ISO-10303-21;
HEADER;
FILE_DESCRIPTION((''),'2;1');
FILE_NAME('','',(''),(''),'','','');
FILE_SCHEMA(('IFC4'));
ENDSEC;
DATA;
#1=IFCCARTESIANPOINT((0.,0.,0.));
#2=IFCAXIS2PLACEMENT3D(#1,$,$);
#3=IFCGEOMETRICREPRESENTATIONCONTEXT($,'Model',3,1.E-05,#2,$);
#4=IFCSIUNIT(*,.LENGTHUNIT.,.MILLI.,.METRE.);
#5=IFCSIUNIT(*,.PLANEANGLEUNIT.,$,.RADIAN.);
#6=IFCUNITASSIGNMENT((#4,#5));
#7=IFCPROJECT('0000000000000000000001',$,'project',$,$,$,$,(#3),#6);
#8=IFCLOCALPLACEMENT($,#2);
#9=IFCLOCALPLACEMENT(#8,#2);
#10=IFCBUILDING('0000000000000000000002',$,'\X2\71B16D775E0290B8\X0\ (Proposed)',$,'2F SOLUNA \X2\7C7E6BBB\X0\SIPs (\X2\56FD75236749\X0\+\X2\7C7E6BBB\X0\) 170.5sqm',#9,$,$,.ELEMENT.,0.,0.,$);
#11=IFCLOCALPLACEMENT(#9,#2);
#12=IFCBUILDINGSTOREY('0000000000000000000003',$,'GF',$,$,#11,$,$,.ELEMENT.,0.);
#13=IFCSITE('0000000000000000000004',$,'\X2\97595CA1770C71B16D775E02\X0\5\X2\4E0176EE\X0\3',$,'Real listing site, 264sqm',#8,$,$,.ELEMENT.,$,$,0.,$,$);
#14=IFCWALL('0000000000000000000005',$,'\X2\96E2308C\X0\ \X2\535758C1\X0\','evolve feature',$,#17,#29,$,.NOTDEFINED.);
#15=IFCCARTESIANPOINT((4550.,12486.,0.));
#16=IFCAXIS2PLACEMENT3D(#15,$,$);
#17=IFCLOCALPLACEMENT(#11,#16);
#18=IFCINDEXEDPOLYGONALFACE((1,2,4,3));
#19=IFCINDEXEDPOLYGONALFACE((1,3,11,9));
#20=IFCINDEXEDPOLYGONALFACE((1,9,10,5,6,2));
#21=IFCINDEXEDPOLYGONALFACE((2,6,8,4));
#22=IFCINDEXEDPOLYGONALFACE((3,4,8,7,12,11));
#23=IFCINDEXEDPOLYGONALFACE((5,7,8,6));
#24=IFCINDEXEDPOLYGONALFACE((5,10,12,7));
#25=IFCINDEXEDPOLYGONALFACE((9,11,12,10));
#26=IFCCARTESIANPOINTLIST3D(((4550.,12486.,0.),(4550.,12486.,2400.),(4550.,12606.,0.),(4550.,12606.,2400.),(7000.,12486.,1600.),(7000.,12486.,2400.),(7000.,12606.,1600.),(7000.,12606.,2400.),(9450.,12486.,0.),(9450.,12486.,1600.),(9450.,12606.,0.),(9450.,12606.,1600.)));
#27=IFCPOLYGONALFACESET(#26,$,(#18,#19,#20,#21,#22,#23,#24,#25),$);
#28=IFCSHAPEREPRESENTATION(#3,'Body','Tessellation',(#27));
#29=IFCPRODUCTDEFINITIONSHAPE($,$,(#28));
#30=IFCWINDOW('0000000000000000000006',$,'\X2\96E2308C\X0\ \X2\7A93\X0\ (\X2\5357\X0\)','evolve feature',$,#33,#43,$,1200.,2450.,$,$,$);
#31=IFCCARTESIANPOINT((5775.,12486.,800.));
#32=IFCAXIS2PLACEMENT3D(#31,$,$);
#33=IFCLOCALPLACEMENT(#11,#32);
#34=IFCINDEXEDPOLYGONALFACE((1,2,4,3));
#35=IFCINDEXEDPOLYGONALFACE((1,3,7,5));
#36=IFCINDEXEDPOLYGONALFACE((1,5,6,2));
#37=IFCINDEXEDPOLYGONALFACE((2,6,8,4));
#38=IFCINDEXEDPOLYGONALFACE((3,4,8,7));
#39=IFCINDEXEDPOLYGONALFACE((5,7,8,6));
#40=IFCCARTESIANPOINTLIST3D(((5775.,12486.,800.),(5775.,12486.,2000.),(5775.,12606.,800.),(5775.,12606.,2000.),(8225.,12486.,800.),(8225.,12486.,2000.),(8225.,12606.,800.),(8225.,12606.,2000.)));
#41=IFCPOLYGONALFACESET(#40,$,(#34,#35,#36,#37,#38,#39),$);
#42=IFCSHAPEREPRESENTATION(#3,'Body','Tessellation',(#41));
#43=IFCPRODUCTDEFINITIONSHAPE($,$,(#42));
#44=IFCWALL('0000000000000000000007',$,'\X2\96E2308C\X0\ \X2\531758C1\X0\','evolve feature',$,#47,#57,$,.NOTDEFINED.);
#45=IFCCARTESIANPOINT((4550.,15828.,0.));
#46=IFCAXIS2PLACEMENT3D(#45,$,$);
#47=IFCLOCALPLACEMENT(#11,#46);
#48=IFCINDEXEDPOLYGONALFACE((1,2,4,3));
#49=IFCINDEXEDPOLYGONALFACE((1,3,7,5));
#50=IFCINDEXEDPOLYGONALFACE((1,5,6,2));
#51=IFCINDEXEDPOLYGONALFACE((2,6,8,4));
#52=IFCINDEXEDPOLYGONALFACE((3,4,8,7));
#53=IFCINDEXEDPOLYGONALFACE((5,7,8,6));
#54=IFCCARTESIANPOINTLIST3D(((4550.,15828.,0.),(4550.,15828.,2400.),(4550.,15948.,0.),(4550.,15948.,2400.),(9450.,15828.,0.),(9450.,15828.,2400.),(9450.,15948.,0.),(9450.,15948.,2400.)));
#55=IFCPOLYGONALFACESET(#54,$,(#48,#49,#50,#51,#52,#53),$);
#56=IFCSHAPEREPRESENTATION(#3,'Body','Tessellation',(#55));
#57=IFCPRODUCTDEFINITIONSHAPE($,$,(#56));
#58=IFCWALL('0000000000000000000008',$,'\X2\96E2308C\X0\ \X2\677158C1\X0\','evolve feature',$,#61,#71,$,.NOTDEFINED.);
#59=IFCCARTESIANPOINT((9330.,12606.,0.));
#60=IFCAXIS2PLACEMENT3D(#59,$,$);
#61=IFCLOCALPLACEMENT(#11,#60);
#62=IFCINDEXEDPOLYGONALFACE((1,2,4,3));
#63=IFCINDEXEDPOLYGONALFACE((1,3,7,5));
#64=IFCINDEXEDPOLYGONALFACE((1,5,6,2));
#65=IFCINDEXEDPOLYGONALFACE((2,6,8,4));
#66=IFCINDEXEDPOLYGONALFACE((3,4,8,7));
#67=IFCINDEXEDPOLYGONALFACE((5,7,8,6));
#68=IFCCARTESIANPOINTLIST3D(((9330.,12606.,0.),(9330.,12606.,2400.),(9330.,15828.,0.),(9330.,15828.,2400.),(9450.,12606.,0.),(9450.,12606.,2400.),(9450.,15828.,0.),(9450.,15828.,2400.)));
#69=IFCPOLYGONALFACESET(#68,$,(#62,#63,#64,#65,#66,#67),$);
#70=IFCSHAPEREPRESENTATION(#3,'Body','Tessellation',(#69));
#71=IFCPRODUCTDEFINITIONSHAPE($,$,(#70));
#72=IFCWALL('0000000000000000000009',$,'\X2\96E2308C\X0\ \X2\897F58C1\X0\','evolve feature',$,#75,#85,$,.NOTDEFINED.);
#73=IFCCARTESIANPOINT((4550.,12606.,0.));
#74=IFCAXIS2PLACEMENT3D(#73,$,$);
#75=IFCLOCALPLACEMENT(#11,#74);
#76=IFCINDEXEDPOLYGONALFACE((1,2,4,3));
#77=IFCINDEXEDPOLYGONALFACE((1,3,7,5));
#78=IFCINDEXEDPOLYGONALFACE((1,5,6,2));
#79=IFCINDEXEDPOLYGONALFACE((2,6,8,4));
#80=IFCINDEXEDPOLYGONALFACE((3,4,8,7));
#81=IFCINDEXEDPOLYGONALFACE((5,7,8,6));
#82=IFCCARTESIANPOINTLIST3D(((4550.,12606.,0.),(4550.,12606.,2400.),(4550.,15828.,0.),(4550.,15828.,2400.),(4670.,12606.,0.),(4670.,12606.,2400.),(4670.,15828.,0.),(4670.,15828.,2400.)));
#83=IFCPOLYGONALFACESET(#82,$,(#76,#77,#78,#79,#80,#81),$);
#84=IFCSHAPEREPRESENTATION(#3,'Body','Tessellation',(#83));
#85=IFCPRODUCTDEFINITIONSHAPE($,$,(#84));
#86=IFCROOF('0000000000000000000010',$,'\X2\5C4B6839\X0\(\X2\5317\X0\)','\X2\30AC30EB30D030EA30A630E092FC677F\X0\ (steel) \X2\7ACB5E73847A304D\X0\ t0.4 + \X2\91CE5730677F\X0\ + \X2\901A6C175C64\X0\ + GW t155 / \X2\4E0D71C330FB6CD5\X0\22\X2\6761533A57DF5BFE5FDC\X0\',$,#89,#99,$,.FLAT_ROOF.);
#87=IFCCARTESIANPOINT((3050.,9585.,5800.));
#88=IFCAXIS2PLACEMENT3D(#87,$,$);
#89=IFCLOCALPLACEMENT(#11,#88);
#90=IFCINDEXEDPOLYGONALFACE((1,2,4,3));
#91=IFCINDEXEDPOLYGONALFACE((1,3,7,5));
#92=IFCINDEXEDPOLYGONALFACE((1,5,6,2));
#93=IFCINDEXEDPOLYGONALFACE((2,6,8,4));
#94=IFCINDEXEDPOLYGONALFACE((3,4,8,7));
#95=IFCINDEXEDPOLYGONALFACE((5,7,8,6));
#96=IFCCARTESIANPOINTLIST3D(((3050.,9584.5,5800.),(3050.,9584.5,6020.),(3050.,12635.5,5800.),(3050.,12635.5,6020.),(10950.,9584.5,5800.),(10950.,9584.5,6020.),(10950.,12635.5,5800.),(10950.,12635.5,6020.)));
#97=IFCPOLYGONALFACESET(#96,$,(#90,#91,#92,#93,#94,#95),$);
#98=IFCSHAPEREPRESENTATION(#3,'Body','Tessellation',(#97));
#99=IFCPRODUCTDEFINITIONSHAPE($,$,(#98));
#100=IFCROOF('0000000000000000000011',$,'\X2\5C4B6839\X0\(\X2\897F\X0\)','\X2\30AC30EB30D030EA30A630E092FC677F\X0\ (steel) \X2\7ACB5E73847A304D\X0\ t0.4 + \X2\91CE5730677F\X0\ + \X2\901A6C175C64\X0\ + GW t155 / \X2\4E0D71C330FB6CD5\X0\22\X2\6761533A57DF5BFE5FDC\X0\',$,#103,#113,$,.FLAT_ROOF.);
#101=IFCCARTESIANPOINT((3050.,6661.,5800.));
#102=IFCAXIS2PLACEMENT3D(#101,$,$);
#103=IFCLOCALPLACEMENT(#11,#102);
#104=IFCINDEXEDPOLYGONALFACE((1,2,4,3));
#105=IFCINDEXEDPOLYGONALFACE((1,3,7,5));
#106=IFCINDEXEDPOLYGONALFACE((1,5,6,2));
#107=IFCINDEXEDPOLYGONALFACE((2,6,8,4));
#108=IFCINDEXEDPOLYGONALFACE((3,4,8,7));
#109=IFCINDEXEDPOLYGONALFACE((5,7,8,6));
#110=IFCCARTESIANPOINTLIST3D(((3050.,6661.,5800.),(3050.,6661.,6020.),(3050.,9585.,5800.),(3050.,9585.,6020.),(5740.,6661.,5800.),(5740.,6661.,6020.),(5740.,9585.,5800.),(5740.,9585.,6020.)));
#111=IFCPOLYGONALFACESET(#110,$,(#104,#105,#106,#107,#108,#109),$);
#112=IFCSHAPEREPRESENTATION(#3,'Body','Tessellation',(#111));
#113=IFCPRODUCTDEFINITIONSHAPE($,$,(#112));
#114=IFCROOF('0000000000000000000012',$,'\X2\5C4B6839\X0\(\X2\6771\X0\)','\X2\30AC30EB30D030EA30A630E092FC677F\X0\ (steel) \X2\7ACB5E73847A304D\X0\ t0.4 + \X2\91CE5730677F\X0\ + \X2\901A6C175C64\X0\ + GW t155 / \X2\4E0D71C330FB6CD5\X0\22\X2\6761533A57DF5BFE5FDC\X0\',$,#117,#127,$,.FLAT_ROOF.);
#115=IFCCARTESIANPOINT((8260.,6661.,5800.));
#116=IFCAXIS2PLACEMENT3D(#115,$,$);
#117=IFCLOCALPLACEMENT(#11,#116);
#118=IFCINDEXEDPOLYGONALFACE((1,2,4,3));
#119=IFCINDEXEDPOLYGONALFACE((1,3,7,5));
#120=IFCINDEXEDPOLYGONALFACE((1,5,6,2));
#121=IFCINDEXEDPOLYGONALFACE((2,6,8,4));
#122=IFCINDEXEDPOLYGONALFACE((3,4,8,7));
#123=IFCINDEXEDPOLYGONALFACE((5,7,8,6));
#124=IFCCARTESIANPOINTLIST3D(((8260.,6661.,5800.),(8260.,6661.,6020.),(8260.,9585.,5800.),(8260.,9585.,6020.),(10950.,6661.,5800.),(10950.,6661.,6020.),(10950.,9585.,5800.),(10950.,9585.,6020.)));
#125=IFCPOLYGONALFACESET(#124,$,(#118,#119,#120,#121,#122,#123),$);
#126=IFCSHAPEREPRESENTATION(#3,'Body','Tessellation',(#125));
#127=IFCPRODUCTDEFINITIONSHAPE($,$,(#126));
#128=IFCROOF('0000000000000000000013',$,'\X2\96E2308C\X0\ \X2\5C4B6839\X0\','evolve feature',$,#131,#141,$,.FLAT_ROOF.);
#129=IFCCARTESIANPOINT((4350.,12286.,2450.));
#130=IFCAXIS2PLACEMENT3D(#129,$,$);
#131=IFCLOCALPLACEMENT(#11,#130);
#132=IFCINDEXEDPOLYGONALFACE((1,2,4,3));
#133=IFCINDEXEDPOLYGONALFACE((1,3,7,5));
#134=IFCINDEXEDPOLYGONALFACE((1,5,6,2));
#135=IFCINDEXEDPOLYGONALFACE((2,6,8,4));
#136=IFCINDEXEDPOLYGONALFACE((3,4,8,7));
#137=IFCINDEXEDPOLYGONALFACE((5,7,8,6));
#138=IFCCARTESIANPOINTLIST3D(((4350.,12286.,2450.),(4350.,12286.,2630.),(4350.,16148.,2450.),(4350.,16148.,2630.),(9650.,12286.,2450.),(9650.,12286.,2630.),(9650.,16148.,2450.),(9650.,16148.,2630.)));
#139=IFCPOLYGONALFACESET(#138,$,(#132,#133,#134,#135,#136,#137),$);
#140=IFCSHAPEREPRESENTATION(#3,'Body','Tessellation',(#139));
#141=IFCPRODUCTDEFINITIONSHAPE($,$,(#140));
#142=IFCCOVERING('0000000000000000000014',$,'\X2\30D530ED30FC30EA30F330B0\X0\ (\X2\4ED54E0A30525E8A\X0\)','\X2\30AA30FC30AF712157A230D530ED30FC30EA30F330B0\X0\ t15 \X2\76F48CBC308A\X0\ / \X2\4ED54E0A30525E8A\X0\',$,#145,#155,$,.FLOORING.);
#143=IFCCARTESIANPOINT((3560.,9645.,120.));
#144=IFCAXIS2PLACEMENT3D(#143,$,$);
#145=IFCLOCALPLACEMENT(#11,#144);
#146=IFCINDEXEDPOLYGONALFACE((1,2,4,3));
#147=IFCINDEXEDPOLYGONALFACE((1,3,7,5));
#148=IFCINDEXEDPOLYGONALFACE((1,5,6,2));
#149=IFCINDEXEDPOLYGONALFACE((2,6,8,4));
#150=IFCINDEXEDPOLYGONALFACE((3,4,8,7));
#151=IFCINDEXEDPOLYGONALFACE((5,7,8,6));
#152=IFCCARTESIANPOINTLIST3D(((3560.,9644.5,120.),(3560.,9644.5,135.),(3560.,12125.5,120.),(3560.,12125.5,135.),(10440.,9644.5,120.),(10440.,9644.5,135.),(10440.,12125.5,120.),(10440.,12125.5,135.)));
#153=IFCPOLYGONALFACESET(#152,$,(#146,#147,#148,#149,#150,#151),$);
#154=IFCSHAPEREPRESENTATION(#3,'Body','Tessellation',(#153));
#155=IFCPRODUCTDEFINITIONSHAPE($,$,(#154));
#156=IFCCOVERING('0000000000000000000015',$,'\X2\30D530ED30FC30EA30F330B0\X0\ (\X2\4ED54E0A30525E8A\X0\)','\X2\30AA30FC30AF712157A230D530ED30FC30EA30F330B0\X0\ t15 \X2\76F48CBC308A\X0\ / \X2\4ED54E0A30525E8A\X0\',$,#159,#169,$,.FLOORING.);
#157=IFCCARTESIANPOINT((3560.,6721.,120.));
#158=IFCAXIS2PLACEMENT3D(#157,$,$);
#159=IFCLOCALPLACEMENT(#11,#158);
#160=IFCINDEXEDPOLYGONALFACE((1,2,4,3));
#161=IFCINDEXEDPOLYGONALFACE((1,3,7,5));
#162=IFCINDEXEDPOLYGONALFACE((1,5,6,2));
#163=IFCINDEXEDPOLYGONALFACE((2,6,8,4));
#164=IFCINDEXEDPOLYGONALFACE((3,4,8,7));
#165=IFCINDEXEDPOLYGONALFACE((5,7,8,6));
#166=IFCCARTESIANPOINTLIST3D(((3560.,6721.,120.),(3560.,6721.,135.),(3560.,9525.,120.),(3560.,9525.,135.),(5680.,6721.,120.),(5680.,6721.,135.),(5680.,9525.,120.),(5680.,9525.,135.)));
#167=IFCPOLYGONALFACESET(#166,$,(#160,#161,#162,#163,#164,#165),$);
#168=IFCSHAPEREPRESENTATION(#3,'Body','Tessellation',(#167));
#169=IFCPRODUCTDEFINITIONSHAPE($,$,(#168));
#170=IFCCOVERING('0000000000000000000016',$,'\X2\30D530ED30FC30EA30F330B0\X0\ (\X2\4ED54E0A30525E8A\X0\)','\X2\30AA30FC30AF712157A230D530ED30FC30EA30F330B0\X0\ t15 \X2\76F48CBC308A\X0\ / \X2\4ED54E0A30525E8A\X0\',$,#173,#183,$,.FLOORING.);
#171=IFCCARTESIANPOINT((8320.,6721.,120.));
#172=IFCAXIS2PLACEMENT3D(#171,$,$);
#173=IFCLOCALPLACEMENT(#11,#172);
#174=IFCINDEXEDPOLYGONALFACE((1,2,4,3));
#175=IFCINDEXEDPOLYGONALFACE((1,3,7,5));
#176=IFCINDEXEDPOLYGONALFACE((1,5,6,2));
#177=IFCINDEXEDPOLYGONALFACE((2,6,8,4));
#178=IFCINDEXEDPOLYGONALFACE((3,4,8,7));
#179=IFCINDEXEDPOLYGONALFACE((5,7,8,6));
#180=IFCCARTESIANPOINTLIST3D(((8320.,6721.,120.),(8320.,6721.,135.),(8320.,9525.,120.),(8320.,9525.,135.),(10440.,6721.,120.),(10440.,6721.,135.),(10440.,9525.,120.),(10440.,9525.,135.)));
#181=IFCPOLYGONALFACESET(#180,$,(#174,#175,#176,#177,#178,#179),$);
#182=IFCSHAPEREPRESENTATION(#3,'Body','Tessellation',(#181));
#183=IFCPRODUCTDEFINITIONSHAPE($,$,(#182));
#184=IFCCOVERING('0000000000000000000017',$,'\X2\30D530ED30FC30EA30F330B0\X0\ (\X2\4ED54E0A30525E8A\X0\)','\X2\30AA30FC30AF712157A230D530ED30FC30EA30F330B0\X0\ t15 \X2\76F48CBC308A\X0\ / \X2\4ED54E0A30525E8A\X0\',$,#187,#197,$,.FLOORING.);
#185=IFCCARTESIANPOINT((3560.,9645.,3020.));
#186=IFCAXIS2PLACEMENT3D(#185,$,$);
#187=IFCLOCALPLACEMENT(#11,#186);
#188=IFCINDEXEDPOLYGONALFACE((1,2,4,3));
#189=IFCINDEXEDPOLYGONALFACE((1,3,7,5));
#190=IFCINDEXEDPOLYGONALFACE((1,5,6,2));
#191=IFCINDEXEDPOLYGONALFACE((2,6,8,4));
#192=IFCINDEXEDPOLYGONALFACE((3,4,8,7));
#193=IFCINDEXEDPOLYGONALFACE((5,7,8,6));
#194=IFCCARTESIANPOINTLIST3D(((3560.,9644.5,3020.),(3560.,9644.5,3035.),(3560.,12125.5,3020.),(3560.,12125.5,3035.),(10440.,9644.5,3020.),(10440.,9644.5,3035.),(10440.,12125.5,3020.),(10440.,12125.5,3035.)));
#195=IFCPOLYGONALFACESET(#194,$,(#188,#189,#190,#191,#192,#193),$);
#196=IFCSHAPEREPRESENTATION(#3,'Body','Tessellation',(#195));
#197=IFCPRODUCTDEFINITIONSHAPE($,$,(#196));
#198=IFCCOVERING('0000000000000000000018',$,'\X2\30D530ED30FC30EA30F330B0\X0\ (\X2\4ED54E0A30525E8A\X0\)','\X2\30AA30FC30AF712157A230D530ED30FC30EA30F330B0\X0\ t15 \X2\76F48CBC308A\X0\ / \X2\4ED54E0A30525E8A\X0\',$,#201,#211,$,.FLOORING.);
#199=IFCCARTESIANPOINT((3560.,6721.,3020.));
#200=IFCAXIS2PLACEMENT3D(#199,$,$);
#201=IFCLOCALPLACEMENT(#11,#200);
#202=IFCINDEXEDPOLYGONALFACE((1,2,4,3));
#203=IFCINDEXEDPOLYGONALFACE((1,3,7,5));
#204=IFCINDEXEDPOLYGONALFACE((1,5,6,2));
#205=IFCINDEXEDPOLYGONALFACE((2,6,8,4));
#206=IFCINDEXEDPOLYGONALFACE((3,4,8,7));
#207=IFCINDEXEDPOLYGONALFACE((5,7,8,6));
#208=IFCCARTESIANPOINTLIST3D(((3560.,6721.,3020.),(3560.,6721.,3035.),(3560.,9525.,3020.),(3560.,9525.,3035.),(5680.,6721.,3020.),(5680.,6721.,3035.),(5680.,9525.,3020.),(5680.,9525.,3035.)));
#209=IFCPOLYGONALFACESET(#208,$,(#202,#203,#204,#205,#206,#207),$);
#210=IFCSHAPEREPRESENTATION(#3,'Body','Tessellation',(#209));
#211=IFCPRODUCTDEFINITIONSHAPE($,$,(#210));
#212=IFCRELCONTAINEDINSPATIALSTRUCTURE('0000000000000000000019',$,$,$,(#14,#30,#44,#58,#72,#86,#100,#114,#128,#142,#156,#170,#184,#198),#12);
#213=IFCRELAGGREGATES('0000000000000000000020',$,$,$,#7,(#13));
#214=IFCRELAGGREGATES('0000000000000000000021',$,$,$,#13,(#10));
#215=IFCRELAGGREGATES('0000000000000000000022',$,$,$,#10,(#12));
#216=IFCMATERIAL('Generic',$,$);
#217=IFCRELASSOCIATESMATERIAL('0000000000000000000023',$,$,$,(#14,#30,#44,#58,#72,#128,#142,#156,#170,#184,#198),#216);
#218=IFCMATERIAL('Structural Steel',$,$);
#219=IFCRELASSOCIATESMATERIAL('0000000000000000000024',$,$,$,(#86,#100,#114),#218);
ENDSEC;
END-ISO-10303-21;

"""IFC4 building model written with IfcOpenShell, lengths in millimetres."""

from ifc_helpers import new_model, si_unit, frame, frame_2d, origin, place, context, project, spatial, rectangle, extrude, material, element, fill, save


model = new_model("IFC4")

# Units and contexts
model_context = context("Model", 3, precision=1e-05, world=origin())
ifc_project = project(units=[si_unit("LENGTHUNIT", "METRE", prefix="MILLI"), si_unit("PLANEANGLEUNIT", "RADIAN")], contexts=[model_context])

# Site, building, storey
site_placement = place(None, origin())
site = spatial("IfcSite", under=ifc_project, at=site_placement, Name="静岡県熱海市5丁目3", ObjectType="Real listing site, 264sqm", CompositionType="ELEMENT", RefElevation=0.0)
building_placement = place(site_placement, origin())
building = spatial("IfcBuilding", under=site, at=building_placement, Name="熱海市邸 (Proposed)", ObjectType="2F SOLUNA 籾殻SIPs (国産杉+籾殻) 170.5sqm", CompositionType="ELEMENT", ElevationOfRefHeight=0.0, ElevationOfTerrain=0.0)
storey_placement = place(building_placement, origin())
storey = spatial("IfcBuildingStorey", under=building, at=storey_placement, Name="GF", CompositionType="ELEMENT", Elevation=0.0)

# Shared definitions
ifc_material_1 = material(Name="Generic")

# Wall, opening, window
wall_1_placement = place(storey_placement, frame((4550.0, 12486.0, 0.0)))
wall_1 = element("IfcWall", 1, at=wall_1_placement, inside=storey, material=ifc_material_1, Name="離れ 南壁", Description="evolve feature", PredefinedType="NOTDEFINED", context=model_context, shape_type="SweptSolid", body=[
    extrude(rectangle(XDim=4900.0, YDim=120.0, at=frame_2d((2450.0, 60.0))), frame((4550.0, 12486.0, 0.0)), (0.0, 0.0, 1.0), 2400.0),
])
opening_1_placement = place(storey_placement, frame((5775.0, 12486.0, 800.0)))
opening_1 = element("IfcOpeningElement", 2, at=opening_1_placement, cuts=wall_1, PredefinedType="NOTDEFINED", context=model_context, shape_type="SweptSolid", body=[
    extrude(rectangle(XDim=2450.0, YDim=120.0, at=frame_2d((1225.0, 60.0))), frame((5775.0, 12486.0, 800.0)), (0.0, 0.0, 1.0), 1200.0),
])
window_1_placement = place(storey_placement, frame((5775.0, 12486.0, 800.0)))
window_1 = element("IfcWindow", 3, at=window_1_placement, inside=storey, material=ifc_material_1, Name="離れ 窓 (南)", Description="evolve feature", OverallHeight=1200.0, OverallWidth=2450.0, context=model_context, shape_type="SweptSolid", body=[
    extrude(rectangle(XDim=2450.0, YDim=120.0, at=frame_2d((1225.0, 60.0))), frame((5775.0, 12486.0, 800.0)), (0.0, 0.0, 1.0), 1200.0),
])
fill(opening_1, window_1)

# Walls
wall_2_placement = place(storey_placement, frame((4550.0, 15828.0, 0.0)))
element("IfcWall", 4, at=wall_2_placement, inside=storey, material=ifc_material_1, Name="離れ 北壁", Description="evolve feature", PredefinedType="NOTDEFINED", context=model_context, shape_type="SweptSolid", body=[
    extrude(rectangle(XDim=4900.0, YDim=120.0, at=frame_2d((2450.0, 60.0))), frame((4550.0, 15828.0, 0.0)), (0.0, 0.0, 1.0), 2400.0),
])
wall_3_placement = place(storey_placement, frame((9330.0, 12606.0, 0.0)))
element("IfcWall", 5, at=wall_3_placement, inside=storey, material=ifc_material_1, Name="離れ 東壁", Description="evolve feature", PredefinedType="NOTDEFINED", context=model_context, shape_type="SweptSolid", body=[
    extrude(rectangle(XDim=120.0, YDim=3222.0, at=frame_2d((60.0, 1611.0))), frame((9330.0, 12606.0, 0.0)), (0.0, 0.0, 1.0), 2400.0),
])
wall_4_placement = place(storey_placement, frame((4550.0, 12606.0, 0.0)))
element("IfcWall", 6, at=wall_4_placement, inside=storey, material=ifc_material_1, Name="離れ 西壁", Description="evolve feature", PredefinedType="NOTDEFINED", context=model_context, shape_type="SweptSolid", body=[
    extrude(rectangle(XDim=120.0, YDim=3222.0, at=frame_2d((60.0, 1611.0))), frame((4550.0, 12606.0, 0.0)), (0.0, 0.0, 1.0), 2400.0),
])

# Roofs
ifc_material_2 = material(Name="Structural Steel")
for number, where, name in (
    (7, (3050.0, 9585.0, 5800.0), "屋根(北)"),
):
    element("IfcRoof", number, at=place(storey_placement, frame(where)), inside=storey, material=ifc_material_2, Name=name, Description="ガルバリウム鋼板 (steel) 立平葺き t0.4 + 野地板 + 通気層 + GW t155 / 不燃・法22条区域対応", PredefinedType="FLAT_ROOF", context=model_context, shape_type="SweptSolid", body=[
        extrude(rectangle(XDim=7900.0, YDim=3051.0, at=frame_2d((3950.0, 1525.0))), frame((3050.0, 9585.0, 5800.0)), (0.0, 0.0, 1.0), 220.0),
    ])
roof_1_placement = place(storey_placement, frame((3050.0, 6661.0, 5800.0)))
element("IfcRoof", 8, at=roof_1_placement, inside=storey, material=ifc_material_2, Name="屋根(西)", Description="ガルバリウム鋼板 (steel) 立平葺き t0.4 + 野地板 + 通気層 + GW t155 / 不燃・法22条区域対応", PredefinedType="FLAT_ROOF", context=model_context, shape_type="SweptSolid", body=[
    extrude(rectangle(XDim=2690.0, YDim=2924.0, at=frame_2d((1345.0, 1462.0))), frame((3050.0, 6661.0, 5800.0)), (0.0, 0.0, 1.0), 220.0),
])
roof_2_placement = place(storey_placement, frame((8260.0, 6661.0, 5800.0)))
element("IfcRoof", 9, at=roof_2_placement, inside=storey, material=ifc_material_2, Name="屋根(東)", Description="ガルバリウム鋼板 (steel) 立平葺き t0.4 + 野地板 + 通気層 + GW t155 / 不燃・法22条区域対応", PredefinedType="FLAT_ROOF", context=model_context, shape_type="SweptSolid", body=[
    extrude(rectangle(XDim=2690.0, YDim=2924.0, at=frame_2d((1345.0, 1462.0))), frame((8260.0, 6661.0, 5800.0)), (0.0, 0.0, 1.0), 220.0),
])
roof_3_placement = place(storey_placement, frame((4350.0, 12286.0, 2450.0)))
element("IfcRoof", 10, at=roof_3_placement, inside=storey, material=ifc_material_1, Name="離れ 屋根", Description="evolve feature", PredefinedType="FLAT_ROOF", context=model_context, shape_type="SweptSolid", body=[
    extrude(rectangle(XDim=5300.0, YDim=3862.0, at=frame_2d((2650.0, 1931.0))), frame((4350.0, 12286.0, 2450.0)), (0.0, 0.0, 1.0), 180.0),
])

# Coverings
covering_1_placement = place(storey_placement, frame((3560.0, 9645.0, 120.0)))
element("IfcCovering", 11, at=covering_1_placement, inside=storey, material=ifc_material_1, Name="フローリング (仕上げ床)", Description="オーク無垢フローリング t15 直貼り / 仕上げ床", PredefinedType="FLOORING", context=model_context, shape_type="SweptSolid", body=[
    extrude(rectangle(XDim=6880.0, YDim=2481.0, at=frame_2d((3440.0, 1240.0))), frame((3560.0, 9645.0, 120.0)), (0.0, 0.0, 1.0), 15.0),
])
covering_2_placement = place(storey_placement, frame((3560.0, 6721.0, 120.0)))
element("IfcCovering", 12, at=covering_2_placement, inside=storey, material=ifc_material_1, Name="フローリング (仕上げ床)", Description="オーク無垢フローリング t15 直貼り / 仕上げ床", PredefinedType="FLOORING", context=model_context, shape_type="SweptSolid", body=[
    extrude(rectangle(XDim=2120.0, YDim=2804.0, at=frame_2d((1060.0, 1402.0))), frame((3560.0, 6721.0, 120.0)), (0.0, 0.0, 1.0), 15.0),
])
covering_3_placement = place(storey_placement, frame((8320.0, 6721.0, 120.0)))
element("IfcCovering", 13, at=covering_3_placement, inside=storey, material=ifc_material_1, Name="フローリング (仕上げ床)", Description="オーク無垢フローリング t15 直貼り / 仕上げ床", PredefinedType="FLOORING", context=model_context, shape_type="SweptSolid", body=[
    extrude(rectangle(XDim=2120.0, YDim=2804.0, at=frame_2d((1060.0, 1402.0))), frame((8320.0, 6721.0, 120.0)), (0.0, 0.0, 1.0), 15.0),
])
covering_4_placement = place(storey_placement, frame((3560.0, 9645.0, 3020.0)))
element("IfcCovering", 14, at=covering_4_placement, inside=storey, material=ifc_material_1, Name="フローリング (仕上げ床)", Description="オーク無垢フローリング t15 直貼り / 仕上げ床", PredefinedType="FLOORING", context=model_context, shape_type="SweptSolid", body=[
    extrude(rectangle(XDim=6880.0, YDim=2481.0, at=frame_2d((3440.0, 1240.0))), frame((3560.0, 9645.0, 3020.0)), (0.0, 0.0, 1.0), 15.0),
])
covering_5_placement = place(storey_placement, frame((3560.0, 6721.0, 3020.0)))
element("IfcCovering", 15, at=covering_5_placement, inside=storey, material=ifc_material_1, Name="フローリング (仕上げ床)", Description="オーク無垢フローリング t15 直貼り / 仕上げ床", PredefinedType="FLOORING", context=model_context, shape_type="SweptSolid", body=[
    extrude(rectangle(XDim=2120.0, YDim=2804.0, at=frame_2d((1060.0, 1402.0))), frame((3560.0, 6721.0, 3020.0)), (0.0, 0.0, 1.0), 15.0),
])

save(model, "model.ifc")
